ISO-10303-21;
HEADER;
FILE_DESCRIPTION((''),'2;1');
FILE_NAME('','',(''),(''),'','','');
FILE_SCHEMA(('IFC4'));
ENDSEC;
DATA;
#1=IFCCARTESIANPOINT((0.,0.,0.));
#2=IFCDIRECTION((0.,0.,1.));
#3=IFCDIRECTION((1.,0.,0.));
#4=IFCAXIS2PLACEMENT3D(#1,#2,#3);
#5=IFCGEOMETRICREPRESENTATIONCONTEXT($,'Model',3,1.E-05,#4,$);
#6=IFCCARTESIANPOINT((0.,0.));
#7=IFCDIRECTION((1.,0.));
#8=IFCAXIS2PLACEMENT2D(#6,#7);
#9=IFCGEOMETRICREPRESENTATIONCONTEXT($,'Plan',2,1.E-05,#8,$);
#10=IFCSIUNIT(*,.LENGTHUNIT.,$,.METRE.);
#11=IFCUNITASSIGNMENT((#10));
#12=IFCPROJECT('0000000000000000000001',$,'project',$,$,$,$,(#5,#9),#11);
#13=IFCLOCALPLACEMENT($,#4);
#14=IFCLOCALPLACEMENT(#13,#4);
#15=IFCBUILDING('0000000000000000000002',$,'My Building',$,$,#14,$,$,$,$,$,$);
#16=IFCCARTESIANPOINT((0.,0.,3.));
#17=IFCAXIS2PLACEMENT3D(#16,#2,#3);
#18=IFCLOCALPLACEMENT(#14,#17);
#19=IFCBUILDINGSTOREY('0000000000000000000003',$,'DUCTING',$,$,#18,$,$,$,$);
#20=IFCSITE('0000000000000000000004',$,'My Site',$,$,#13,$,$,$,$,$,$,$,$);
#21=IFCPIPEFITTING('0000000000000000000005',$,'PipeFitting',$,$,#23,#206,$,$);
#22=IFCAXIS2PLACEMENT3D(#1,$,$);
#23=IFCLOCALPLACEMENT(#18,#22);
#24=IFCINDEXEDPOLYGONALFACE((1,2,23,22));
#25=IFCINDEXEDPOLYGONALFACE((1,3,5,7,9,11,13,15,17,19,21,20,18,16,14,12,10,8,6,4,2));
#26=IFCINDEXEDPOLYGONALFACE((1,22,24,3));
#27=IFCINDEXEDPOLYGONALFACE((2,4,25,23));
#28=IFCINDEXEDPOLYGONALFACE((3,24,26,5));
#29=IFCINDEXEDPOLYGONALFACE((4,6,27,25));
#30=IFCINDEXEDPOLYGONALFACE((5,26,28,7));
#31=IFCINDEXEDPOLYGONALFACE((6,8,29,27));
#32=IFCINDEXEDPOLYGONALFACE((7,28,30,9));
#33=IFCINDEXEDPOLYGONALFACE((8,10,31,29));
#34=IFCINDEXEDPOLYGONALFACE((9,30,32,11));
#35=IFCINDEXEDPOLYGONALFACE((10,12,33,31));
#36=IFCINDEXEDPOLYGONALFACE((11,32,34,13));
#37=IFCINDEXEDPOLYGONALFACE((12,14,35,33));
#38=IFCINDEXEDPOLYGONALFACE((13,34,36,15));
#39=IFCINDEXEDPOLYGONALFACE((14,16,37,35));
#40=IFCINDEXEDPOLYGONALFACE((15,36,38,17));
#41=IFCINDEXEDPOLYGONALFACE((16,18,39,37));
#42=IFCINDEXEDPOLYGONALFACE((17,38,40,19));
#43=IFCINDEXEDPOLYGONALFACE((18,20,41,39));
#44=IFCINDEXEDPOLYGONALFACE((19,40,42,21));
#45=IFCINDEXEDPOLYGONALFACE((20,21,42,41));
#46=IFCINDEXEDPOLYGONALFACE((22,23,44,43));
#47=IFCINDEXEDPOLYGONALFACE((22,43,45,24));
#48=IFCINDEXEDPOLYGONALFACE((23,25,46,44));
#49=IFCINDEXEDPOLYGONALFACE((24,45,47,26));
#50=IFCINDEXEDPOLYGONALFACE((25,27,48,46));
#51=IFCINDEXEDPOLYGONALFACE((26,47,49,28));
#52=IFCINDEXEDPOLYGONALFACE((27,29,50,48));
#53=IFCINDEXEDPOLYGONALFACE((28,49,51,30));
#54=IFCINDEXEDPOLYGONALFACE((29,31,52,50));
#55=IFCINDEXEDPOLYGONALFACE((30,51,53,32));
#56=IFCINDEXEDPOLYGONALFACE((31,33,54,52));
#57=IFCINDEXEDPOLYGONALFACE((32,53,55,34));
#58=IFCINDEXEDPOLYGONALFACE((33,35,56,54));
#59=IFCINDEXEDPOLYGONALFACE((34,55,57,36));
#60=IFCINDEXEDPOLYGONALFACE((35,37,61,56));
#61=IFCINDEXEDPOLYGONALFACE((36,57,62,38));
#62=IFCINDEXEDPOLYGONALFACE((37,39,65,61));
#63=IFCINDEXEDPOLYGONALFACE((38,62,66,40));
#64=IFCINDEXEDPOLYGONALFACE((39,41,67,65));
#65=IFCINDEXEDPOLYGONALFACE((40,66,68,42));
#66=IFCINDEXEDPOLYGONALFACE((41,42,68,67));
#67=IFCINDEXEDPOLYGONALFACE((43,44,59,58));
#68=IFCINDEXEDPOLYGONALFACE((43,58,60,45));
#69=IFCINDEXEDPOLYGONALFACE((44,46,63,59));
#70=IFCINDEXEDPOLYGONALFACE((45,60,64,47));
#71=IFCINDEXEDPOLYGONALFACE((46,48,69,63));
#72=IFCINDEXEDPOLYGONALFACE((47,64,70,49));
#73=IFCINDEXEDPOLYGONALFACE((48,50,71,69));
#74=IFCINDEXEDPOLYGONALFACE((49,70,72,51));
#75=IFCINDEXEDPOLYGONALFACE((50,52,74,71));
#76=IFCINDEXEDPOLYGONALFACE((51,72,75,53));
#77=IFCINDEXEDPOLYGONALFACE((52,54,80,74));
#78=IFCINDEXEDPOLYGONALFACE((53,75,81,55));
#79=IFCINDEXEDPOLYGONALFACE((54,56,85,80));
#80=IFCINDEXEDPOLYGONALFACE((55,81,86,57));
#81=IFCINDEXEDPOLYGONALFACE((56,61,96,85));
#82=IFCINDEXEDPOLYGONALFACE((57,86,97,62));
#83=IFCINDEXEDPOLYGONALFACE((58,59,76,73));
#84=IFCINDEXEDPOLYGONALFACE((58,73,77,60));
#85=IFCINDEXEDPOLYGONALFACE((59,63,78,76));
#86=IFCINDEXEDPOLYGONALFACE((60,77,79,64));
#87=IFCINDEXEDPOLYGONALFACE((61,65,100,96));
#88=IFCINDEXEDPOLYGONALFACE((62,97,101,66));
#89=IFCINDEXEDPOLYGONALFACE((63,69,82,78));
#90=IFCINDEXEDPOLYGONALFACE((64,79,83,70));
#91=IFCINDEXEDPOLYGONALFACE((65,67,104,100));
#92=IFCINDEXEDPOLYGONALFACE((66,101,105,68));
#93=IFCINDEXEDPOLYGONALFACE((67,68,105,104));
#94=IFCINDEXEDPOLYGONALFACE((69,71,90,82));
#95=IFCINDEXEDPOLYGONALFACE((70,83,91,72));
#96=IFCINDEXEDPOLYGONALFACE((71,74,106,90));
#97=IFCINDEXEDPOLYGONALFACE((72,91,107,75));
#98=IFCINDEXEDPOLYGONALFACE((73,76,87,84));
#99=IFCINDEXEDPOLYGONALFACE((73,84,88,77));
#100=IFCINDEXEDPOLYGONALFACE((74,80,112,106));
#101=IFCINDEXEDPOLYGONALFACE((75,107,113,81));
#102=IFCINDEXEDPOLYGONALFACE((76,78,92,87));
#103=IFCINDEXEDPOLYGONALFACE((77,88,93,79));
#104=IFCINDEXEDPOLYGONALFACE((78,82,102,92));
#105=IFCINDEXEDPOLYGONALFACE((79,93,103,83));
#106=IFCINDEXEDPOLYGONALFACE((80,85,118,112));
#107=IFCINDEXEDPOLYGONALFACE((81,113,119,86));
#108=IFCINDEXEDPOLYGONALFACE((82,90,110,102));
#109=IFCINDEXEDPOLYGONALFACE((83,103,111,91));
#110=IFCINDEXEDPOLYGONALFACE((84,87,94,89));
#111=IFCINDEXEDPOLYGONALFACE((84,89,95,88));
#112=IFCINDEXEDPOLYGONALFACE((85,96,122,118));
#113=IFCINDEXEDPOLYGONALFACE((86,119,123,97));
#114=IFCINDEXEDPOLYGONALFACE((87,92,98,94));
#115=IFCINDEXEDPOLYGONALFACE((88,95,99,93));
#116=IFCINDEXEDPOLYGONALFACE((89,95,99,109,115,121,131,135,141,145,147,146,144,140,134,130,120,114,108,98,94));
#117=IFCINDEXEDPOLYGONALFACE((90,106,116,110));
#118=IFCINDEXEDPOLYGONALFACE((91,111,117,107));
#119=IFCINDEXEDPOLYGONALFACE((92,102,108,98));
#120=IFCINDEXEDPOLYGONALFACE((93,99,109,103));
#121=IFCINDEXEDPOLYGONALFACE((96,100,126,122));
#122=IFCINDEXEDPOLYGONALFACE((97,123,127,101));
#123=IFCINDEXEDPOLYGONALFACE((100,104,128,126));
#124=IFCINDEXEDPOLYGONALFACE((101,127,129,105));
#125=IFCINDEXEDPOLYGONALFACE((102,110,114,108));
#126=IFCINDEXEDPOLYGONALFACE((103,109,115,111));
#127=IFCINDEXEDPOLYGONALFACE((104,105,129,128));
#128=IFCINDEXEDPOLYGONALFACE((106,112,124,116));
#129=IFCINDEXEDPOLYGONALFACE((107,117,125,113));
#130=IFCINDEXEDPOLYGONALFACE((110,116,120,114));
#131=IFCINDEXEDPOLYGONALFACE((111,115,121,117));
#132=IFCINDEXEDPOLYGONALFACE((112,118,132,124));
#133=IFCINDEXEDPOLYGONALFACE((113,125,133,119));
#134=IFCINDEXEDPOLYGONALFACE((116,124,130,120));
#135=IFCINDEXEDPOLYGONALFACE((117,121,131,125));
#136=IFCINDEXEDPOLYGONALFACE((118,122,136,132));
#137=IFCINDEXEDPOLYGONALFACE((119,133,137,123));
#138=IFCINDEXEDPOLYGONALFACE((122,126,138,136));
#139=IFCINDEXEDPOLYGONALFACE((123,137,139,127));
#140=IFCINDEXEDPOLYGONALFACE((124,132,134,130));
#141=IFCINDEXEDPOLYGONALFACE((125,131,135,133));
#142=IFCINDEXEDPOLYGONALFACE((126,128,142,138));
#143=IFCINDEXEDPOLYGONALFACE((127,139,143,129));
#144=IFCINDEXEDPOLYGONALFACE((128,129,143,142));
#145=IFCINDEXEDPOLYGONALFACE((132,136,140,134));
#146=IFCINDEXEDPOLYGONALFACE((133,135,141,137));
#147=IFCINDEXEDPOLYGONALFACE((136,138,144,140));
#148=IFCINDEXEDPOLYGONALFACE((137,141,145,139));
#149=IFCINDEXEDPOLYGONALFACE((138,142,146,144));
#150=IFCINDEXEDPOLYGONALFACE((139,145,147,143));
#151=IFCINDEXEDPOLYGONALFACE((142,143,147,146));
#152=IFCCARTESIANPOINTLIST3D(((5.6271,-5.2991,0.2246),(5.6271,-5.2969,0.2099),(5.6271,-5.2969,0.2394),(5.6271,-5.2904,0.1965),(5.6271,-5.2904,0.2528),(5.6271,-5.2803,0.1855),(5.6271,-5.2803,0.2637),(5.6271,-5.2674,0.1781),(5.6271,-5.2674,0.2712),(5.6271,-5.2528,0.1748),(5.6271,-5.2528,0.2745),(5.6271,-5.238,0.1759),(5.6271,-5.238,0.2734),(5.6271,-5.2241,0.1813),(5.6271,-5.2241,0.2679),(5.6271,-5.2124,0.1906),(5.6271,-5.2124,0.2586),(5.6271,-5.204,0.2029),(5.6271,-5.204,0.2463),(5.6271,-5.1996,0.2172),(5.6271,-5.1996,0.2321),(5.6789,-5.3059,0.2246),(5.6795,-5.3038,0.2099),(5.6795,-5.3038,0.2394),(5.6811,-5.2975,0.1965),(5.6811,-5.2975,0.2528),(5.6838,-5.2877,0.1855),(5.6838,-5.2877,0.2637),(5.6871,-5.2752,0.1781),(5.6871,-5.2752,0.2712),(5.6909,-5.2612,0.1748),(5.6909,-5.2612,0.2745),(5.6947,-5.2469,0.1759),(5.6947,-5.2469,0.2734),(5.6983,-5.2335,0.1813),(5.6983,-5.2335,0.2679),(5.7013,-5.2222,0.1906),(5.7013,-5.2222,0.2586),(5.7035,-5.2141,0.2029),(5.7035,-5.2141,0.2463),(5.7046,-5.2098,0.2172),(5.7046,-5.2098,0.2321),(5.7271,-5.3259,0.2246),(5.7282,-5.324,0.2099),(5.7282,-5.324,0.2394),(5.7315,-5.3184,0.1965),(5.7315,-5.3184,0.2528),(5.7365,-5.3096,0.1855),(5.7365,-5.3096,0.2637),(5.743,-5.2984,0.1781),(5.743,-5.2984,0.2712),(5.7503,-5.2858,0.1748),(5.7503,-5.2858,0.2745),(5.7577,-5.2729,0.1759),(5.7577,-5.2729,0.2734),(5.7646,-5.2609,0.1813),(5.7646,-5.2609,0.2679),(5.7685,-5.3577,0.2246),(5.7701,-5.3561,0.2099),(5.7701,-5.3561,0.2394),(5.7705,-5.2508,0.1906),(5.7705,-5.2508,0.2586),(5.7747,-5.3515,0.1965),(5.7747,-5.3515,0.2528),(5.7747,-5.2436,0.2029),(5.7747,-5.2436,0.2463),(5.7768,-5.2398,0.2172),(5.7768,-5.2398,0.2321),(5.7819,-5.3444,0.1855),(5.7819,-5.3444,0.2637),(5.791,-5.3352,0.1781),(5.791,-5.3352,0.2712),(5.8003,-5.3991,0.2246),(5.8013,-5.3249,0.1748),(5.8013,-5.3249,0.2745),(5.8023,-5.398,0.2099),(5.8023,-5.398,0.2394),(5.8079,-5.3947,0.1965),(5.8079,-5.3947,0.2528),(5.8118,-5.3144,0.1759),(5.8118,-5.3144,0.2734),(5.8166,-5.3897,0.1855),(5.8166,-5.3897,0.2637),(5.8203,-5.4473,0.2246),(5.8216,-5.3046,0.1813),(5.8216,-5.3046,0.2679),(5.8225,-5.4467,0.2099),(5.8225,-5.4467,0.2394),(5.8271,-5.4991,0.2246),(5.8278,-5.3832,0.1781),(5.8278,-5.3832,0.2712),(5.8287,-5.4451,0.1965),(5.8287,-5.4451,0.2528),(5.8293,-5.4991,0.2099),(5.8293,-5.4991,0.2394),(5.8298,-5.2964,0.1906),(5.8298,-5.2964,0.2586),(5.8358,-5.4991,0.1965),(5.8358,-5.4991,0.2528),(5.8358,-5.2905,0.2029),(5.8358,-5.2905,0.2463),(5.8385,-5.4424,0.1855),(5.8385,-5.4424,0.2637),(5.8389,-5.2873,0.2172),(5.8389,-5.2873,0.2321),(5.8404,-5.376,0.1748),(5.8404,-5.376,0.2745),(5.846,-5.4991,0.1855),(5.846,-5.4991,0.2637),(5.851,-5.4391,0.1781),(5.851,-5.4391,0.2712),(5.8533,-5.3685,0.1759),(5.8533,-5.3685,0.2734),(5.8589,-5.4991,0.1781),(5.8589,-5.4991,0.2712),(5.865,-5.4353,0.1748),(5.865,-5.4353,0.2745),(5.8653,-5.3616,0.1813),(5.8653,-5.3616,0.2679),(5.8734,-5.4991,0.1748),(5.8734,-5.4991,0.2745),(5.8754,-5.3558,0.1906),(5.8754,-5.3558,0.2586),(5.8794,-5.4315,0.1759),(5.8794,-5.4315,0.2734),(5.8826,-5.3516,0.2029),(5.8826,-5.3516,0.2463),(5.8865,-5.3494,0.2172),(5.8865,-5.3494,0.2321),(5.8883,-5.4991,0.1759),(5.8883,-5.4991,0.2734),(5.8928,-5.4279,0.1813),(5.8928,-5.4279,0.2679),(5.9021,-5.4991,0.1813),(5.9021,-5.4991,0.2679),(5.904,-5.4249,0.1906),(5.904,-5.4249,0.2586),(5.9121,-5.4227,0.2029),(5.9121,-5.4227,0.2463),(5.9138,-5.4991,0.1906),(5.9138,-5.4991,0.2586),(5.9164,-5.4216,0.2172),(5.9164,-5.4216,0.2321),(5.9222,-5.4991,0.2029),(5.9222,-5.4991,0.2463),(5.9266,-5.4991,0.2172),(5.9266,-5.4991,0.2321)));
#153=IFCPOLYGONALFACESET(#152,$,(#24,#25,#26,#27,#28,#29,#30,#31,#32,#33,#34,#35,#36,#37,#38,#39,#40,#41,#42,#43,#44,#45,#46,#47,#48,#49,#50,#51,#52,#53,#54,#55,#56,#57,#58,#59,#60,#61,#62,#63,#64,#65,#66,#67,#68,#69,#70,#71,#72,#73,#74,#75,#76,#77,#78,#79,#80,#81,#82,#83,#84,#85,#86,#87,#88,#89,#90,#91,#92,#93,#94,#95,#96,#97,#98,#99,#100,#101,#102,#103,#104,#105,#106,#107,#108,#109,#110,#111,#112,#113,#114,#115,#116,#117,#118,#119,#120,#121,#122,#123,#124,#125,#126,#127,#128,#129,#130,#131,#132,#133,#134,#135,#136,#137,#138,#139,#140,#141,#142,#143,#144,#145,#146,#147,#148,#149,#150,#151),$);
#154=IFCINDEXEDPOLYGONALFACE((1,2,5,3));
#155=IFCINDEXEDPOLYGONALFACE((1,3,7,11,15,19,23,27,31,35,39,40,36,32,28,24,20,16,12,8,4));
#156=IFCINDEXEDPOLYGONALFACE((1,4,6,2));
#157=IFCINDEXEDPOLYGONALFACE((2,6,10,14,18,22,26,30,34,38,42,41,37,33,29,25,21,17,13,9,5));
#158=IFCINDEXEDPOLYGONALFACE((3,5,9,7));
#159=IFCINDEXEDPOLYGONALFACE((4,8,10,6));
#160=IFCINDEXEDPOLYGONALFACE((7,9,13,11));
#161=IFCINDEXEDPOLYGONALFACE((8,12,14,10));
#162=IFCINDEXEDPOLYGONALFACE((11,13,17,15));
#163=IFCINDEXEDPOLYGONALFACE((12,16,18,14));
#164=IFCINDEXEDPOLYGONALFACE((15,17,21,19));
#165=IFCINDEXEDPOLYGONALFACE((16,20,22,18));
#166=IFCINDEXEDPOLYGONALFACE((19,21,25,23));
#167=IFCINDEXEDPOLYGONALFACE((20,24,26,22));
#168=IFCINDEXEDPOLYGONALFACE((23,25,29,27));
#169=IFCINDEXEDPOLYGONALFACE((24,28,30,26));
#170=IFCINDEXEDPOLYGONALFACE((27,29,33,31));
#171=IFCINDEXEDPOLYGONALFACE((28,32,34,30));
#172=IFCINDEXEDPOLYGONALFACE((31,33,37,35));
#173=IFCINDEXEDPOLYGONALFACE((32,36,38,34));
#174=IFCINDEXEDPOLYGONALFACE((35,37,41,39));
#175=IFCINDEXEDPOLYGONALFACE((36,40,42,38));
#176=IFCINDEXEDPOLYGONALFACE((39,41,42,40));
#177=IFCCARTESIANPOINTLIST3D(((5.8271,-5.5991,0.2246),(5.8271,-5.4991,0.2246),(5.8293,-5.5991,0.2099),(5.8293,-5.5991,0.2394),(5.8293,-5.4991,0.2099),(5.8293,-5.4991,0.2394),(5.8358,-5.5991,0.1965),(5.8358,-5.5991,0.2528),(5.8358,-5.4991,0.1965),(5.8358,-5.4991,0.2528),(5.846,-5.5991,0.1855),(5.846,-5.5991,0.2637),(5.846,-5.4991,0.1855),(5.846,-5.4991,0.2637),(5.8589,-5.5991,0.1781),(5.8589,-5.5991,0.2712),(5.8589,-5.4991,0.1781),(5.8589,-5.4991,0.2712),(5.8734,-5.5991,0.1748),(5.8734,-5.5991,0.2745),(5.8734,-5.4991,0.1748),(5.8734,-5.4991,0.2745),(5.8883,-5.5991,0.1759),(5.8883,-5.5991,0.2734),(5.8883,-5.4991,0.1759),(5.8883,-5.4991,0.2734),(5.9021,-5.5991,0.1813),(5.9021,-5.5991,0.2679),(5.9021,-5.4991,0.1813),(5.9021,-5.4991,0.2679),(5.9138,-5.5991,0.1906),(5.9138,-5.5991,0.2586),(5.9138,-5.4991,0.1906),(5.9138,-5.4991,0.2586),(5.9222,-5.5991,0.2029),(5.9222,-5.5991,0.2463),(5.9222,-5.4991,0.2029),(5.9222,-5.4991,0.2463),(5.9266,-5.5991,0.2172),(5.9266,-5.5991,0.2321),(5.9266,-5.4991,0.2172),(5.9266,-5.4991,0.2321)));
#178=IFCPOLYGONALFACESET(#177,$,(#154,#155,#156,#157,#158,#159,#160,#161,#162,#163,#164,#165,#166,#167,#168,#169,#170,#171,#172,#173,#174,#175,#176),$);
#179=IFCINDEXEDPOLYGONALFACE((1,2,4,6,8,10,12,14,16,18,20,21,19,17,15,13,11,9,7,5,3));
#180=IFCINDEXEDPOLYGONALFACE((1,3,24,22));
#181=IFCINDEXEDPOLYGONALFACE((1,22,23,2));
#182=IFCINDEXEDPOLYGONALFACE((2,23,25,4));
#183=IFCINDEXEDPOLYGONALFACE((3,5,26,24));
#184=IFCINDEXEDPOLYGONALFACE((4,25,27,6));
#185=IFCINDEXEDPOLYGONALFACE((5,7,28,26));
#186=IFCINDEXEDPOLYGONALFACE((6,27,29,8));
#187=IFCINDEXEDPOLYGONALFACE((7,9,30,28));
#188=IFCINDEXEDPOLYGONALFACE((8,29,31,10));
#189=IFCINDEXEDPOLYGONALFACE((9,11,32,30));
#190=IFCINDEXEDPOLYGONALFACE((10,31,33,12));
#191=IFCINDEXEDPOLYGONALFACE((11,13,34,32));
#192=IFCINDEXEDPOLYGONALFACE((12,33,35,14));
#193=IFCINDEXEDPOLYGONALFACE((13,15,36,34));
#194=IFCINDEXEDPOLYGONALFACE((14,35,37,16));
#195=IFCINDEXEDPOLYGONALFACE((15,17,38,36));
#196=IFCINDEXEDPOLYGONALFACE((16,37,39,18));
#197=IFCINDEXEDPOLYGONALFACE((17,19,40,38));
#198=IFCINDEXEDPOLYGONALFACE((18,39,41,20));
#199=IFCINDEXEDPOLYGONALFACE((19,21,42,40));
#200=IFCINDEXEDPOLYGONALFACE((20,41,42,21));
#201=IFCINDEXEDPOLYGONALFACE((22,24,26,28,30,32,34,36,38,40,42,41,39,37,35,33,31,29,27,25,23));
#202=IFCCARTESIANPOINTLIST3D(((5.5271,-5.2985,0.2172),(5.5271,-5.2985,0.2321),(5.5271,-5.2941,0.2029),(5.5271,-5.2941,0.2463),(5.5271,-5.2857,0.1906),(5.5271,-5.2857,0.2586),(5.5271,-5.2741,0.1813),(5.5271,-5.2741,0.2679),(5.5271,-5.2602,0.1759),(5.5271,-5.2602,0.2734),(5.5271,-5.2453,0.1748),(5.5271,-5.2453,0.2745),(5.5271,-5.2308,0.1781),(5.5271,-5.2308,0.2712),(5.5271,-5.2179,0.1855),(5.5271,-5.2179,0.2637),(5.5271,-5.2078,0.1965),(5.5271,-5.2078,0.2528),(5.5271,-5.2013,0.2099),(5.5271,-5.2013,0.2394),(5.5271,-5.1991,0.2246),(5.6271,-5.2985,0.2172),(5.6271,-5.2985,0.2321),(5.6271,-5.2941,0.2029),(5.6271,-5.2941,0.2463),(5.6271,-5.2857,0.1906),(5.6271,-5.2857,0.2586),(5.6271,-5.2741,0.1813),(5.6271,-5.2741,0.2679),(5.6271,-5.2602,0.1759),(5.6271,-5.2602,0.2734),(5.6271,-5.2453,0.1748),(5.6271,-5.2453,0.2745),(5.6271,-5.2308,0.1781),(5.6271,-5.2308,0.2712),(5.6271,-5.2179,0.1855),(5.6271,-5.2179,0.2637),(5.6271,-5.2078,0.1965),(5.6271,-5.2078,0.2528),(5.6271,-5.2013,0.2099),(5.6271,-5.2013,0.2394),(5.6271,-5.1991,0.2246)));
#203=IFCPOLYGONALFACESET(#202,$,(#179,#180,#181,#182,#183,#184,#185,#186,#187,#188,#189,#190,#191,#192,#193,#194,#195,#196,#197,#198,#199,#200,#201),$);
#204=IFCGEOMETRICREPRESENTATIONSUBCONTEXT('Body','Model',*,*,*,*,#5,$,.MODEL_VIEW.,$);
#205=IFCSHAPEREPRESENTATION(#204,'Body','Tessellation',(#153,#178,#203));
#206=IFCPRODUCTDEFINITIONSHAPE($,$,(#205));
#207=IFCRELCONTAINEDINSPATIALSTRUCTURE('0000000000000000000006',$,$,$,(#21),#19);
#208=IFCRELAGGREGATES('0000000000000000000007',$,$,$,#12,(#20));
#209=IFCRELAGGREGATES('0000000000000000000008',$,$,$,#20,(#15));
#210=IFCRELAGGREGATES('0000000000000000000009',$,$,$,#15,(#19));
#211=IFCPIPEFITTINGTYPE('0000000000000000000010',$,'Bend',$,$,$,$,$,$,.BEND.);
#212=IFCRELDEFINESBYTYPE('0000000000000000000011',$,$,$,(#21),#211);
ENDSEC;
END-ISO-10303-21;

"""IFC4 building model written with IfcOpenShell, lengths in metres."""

from ifc_helpers import new_model, entity, si_unit, frame, origin_with_axes, origin_2d_with_axis, place, context, subcontext, project, spatial, circle, extrude, source, transform, mapped, type_object, type_shapes, element, save


model = new_model("IFC4")

# Units and contexts
model_context = context("Model", 3, precision=1e-05, world=origin_with_axes())
plan_context = context("Plan", 2, precision=1e-05, world=origin_2d_with_axis())
body_context = subcontext(model_context, "Body", "Model", "MODEL_VIEW")
ifc_project = project(units=[si_unit("LENGTHUNIT", "METRE")], contexts=[model_context, plan_context])

# Site, building, storey
site_placement = place(None, origin_with_axes())
site = spatial("IfcSite", under=ifc_project, at=site_placement, Name="My Site")
building_placement = place(site_placement, origin_with_axes())
building = spatial("IfcBuilding", under=site, at=building_placement, Name="My Building")
storey_placement = place(building_placement, frame((0.0, 0.0, 3.0), z_axis=(0.0, 0.0, 1.0), x_axis=(1.0, 0.0, 0.0)))
storey = spatial("IfcBuildingStorey", under=building, at=storey_placement, Name="DUCTING")

# Pipe fitting
pipe_fitting_type = type_object("IfcPipeFittingType", Name="Bend", PredefinedType="BEND")
shared_shape_1 = source(origin_with_axes(), body_context, "Body", "SolidModel", [
    entity("IfcSweptDiskSolid", entity("IfcIndexedPolyCurve", entity("IfcCartesianPointList3D", [[0.0, 0.0, 0.1], [0.0732, 0.0, 0.2768], [0.25, 0.0, 0.35]]), [entity("IfcArcIndex", [1, 2, 3])]), 0.05),
    extrude(circle(Radius=0.05), origin_with_axes(), (0.0, 0.0, 1.0), 0.1),
    extrude(circle(Radius=0.05), frame((0.25, 0.0, 0.35), z_axis=(1.0, 0.0, 0.0), x_axis=(0.0, 0.0, 1.0)), (0.0, 0.0, 1.0), 0.1),
])
type_shapes(pipe_fitting_type, [shared_shape_1])
for number, where, z_axis, x_axis, name in (
    (1, (5.8771, -5.5991, 0.2246), (0.0, 1.0, 0.0), (-1.0, 0.0, 0.0), "PipeFitting"),
):
    element("IfcPipeFitting", number, at=place(storey_placement, frame(where, z_axis=z_axis, x_axis=x_axis)), inside=storey, type_object=pipe_fitting_type, Name=name, context=body_context, shape_type="MappedRepresentation", body=[
        mapped(shared_shape_1, transform((0.0, 0.0, 0.0), x_axis=(1.0, 0.0, 0.0), y_axis=(0.0, 1.0, 0.0), z_axis=(0.0, 0.0, 1.0), scale=1.0)),
    ])

save(model, "model.ifc")
